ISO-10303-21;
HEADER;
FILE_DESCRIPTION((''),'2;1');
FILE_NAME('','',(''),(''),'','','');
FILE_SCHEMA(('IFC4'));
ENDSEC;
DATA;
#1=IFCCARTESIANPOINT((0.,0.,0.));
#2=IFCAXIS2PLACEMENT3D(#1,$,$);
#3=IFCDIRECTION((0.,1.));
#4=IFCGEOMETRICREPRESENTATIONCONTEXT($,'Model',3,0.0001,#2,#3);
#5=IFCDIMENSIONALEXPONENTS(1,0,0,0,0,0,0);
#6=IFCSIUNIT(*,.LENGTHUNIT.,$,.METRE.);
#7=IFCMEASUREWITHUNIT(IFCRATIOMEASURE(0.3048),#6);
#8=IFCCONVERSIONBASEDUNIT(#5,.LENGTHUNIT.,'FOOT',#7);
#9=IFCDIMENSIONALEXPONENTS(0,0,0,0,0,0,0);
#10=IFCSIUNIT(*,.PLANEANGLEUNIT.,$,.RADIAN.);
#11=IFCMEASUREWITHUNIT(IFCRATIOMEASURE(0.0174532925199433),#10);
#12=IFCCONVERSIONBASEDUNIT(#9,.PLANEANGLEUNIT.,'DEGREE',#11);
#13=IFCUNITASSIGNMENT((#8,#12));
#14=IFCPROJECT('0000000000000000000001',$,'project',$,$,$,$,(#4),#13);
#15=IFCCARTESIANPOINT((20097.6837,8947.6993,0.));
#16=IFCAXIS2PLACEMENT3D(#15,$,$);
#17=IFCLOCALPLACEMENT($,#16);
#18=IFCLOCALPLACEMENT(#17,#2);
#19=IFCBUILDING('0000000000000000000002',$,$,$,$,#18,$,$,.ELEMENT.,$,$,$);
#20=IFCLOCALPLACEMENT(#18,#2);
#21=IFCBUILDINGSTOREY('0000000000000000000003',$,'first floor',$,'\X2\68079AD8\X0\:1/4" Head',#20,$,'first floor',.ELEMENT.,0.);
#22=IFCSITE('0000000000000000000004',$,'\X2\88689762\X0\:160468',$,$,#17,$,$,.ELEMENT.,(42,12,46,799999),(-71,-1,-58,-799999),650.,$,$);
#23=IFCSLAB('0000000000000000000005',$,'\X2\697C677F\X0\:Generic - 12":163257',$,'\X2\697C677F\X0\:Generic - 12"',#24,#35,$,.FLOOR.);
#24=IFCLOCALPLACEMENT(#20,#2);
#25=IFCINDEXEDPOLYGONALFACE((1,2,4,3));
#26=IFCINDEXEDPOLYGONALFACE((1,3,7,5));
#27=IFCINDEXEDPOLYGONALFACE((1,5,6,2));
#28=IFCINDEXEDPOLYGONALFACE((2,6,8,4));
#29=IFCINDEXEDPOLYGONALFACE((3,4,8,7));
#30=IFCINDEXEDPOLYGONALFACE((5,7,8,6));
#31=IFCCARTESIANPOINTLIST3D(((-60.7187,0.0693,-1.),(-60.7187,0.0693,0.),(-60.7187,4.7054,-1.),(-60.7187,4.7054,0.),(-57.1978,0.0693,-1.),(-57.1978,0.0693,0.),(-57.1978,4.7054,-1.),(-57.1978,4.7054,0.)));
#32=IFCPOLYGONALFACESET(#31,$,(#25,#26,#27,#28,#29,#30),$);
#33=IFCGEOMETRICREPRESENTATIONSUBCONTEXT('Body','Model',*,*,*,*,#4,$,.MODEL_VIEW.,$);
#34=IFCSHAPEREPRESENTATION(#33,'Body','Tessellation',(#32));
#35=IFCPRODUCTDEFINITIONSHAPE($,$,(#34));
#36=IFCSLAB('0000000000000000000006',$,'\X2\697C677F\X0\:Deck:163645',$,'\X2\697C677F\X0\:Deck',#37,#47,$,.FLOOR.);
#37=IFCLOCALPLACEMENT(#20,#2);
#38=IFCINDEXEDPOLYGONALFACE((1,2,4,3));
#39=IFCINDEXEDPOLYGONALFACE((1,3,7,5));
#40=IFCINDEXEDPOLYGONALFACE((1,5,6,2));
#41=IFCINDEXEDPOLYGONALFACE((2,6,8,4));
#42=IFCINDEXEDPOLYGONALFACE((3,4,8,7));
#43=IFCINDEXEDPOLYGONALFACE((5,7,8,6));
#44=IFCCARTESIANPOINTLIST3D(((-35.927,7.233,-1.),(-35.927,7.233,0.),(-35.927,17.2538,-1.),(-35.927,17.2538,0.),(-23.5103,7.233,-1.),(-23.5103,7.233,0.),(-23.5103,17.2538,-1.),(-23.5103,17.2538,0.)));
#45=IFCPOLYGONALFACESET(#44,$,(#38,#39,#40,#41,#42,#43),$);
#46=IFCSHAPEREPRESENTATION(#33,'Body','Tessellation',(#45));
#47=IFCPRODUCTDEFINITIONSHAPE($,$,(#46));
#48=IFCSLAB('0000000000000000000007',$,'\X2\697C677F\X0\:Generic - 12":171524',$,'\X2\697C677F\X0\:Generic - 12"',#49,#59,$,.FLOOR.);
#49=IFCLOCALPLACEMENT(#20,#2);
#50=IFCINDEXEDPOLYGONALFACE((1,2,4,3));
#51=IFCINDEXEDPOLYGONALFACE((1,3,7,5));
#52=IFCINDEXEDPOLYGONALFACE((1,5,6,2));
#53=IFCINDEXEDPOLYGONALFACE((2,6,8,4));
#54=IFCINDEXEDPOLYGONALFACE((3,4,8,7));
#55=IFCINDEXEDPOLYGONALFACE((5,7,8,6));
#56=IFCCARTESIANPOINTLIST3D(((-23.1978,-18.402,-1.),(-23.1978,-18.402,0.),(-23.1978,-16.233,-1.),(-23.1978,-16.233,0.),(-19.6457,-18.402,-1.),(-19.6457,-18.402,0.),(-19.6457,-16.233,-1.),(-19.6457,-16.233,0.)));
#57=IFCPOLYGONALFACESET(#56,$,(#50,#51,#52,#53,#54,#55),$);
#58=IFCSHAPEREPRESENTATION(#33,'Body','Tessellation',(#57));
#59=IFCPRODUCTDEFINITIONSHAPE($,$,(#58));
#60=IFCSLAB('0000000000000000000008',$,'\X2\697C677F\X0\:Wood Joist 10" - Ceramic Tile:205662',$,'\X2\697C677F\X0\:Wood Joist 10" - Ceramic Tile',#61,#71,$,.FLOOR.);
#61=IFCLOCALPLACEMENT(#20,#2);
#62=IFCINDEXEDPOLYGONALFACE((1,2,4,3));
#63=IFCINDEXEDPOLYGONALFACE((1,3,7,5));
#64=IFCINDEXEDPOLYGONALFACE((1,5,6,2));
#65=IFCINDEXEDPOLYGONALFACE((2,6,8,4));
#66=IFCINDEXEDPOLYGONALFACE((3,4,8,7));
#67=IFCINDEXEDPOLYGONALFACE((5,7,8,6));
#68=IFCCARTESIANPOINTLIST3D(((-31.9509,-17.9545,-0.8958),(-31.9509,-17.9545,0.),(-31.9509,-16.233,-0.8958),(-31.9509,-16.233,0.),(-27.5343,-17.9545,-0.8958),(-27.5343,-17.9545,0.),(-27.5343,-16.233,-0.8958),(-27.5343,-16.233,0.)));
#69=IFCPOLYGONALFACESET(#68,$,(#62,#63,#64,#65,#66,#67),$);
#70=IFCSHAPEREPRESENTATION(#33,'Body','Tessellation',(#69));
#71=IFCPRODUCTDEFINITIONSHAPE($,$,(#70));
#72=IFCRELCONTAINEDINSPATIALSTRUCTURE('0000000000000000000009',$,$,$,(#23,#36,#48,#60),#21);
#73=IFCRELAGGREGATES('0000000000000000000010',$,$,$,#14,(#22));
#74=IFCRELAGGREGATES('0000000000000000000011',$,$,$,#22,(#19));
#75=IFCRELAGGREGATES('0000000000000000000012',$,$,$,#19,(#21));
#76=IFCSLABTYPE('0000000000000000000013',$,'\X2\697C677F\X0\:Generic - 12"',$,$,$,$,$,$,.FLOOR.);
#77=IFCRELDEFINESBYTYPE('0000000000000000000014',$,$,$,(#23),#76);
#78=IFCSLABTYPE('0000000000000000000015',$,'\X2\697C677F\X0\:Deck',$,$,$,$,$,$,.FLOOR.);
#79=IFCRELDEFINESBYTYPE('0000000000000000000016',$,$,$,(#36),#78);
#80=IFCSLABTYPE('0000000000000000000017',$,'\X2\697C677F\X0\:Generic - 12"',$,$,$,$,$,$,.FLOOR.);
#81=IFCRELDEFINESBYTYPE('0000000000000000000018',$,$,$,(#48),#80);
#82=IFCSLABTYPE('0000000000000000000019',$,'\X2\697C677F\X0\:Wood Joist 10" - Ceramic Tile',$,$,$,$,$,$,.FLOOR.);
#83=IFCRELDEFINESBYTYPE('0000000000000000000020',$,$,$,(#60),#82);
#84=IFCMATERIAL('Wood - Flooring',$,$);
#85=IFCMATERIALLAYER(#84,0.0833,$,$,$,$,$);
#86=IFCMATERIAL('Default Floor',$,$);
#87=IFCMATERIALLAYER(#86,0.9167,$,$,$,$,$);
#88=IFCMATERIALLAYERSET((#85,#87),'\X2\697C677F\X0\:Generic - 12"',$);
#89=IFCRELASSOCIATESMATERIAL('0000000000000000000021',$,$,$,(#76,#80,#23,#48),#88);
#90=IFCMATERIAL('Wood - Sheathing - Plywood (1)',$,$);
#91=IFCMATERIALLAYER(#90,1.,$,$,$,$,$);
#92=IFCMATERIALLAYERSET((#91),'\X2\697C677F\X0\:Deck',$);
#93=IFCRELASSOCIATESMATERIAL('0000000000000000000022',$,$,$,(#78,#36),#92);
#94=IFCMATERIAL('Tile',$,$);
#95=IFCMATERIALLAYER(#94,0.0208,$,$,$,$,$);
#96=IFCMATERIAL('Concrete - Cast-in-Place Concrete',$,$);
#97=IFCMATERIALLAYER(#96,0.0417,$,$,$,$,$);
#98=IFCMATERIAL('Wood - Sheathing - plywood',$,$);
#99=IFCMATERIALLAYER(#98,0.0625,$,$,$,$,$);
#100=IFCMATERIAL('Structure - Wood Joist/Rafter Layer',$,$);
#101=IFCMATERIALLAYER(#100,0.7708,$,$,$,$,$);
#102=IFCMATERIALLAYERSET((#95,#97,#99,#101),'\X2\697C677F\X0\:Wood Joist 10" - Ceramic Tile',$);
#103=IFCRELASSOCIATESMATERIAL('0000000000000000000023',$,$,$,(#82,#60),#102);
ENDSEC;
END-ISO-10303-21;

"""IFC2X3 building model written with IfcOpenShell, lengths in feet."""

from ifc_helpers import new_model, entity, si_unit, converted_unit, direction, frame, frame_2d, origin, origin_2d_with_axis, place, context, subcontext, project, spatial, rectangle, extrude, material, layer, layer_set, layer_usage, type_object, element, save


model = new_model("IFC2X3")

# Units and contexts
model_context = context("Model", 3, precision=0.0001, world=origin(), true_north=direction((0.0, 1.0)))
body_context = subcontext(model_context, "Body", "Model", "MODEL_VIEW")
ifc_project = project(units=[converted_unit("LENGTHUNIT", "FOOT", entity("IfcRatioMeasure", 0.3048), si_unit("LENGTHUNIT", "METRE"), dimensions=[1, 0, 0, 0, 0, 0, 0]), converted_unit("PLANEANGLEUNIT", "DEGREE", entity("IfcRatioMeasure", 0.0174532925199433), si_unit("PLANEANGLEUNIT", "RADIAN"), dimensions=[0, 0, 0, 0, 0, 0, 0])], contexts=[model_context])

# Site, building, storey
site_placement = place(None, frame((20097.6837, 8947.6993, 0.0)))
site = spatial("IfcSite", under=ifc_project, at=site_placement, Name="表面:160468", CompositionType="ELEMENT", RefLatitude=(42, 12, 46, 799999), RefLongitude=(-71, -1, -58, -799999), RefElevation=650.0)
building_placement = place(site_placement, origin())
building = spatial("IfcBuilding", under=site, at=building_placement, CompositionType="ELEMENT")
storey_placement = place(building_placement, origin())
storey = spatial("IfcBuildingStorey", under=building, at=storey_placement, Name="first floor", ObjectType="标高:1/4\" Head", LongName="first floor", CompositionType="ELEMENT", Elevation=0.0)

# Slabs
ifc_material_1 = material(Name="Wood - Flooring")
ifc_layer_1 = layer(ifc_material_1, 0.0833)
ifc_material_2 = material(Name="Default Floor")
ifc_layer_2 = layer(ifc_material_2, 0.9167)
ifc_layer_set_1 = layer_set([ifc_layer_1, ifc_layer_2], Name="楼板:Generic - 12\"")
ifc_layer_usage_1 = layer_usage(ifc_layer_set_1, "AXIS3", "POSITIVE", 0.0)
slab_type_1 = type_object("IfcSlabType", Name="楼板:Generic - 12\"", PredefinedType="FLOOR", material=ifc_layer_set_1)
slab_1_placement = place(storey_placement, origin())
element("IfcSlab", 1, at=slab_1_placement, inside=storey, type_object=slab_type_1, material=ifc_layer_usage_1, Name="楼板:Generic - 12\":163257", ObjectType="楼板:Generic - 12\"", PredefinedType="FLOOR", context=body_context, shape_type="SweptSolid", body=[
    extrude(rectangle(XDim=4.6361, YDim=3.5208, at=frame_2d((0.0, 0.0), x_axis=(1.0, 0.0))), frame((-58.9582, 2.3874, 0.0), z_axis=(0.0, 0.0, -1.0), x_axis=(0.0, 1.0, 0.0)), (0.0, 0.0, 1.0), 1.0),
])
ifc_material_3 = material(Name="Wood - Sheathing - Plywood (1)")
ifc_layer_3 = layer(ifc_material_3, 1.0)
ifc_layer_set_2 = layer_set([ifc_layer_3], Name="楼板:Deck")
ifc_layer_usage_2 = layer_usage(ifc_layer_set_2, "AXIS3", "POSITIVE", 0.0)
slab_type_2 = type_object("IfcSlabType", Name="楼板:Deck", PredefinedType="FLOOR", material=ifc_layer_set_2)
slab_2_placement = place(storey_placement, origin())
element("IfcSlab", 2, at=slab_2_placement, inside=storey, type_object=slab_type_2, material=ifc_layer_usage_2, Name="楼板:Deck:163645", ObjectType="楼板:Deck", PredefinedType="FLOOR", context=body_context, shape_type="SweptSolid", body=[
    extrude(rectangle(XDim=10.0208, YDim=12.4167, at=frame_2d((0.0, 0.0), x_axis=(1.0, 0.0))), frame((-29.7187, 12.2434, 0.0), z_axis=(0.0, 0.0, -1.0), x_axis=(0.0, 1.0, 0.0)), (0.0, 0.0, 1.0), 1.0),
])
ifc_layer_usage_3 = layer_usage(ifc_layer_set_1, "AXIS3", "POSITIVE", 0.0)
slab_type_3 = type_object("IfcSlabType", Name="楼板:Generic - 12\"", PredefinedType="FLOOR", material=ifc_layer_set_1)
slab_3_placement = place(storey_placement, origin())
element("IfcSlab", 3, at=slab_3_placement, inside=storey, type_object=slab_type_3, material=ifc_layer_usage_3, Name="楼板:Generic - 12\":171524", ObjectType="楼板:Generic - 12\"", PredefinedType="FLOOR", context=body_context, shape_type="SweptSolid", body=[
    extrude(rectangle(XDim=2.1691, YDim=3.5521, at=origin_2d_with_axis()), frame((-21.4218, -17.3175, 0.0), z_axis=(0.0, 0.0, -1.0), x_axis=(0.0, 1.0, 0.0)), (0.0, 0.0, 1.0), 1.0),
])
ifc_material_4 = material(Name="Tile")
ifc_layer_4 = layer(ifc_material_4, 0.0208)
ifc_material_5 = material(Name="Concrete - Cast-in-Place Concrete")
ifc_layer_5 = layer(ifc_material_5, 0.0417)
ifc_material_6 = material(Name="Wood - Sheathing - plywood")
ifc_layer_6 = layer(ifc_material_6, 0.0625)
ifc_material_7 = material(Name="Structure - Wood Joist/Rafter Layer")
ifc_layer_7 = layer(ifc_material_7, 0.7708)
ifc_layer_set_3 = layer_set([ifc_layer_4, ifc_layer_5, ifc_layer_6, ifc_layer_7], Name="楼板:Wood Joist 10\" - Ceramic Tile")
ifc_layer_usage_4 = layer_usage(ifc_layer_set_3, "AXIS3", "POSITIVE", 0.0)
slab_type_4 = type_object("IfcSlabType", Name="楼板:Wood Joist 10\" - Ceramic Tile", PredefinedType="FLOOR", material=ifc_layer_set_3)
slab_4_placement = place(storey_placement, origin())
element("IfcSlab", 4, at=slab_4_placement, inside=storey, type_object=slab_type_4, material=ifc_layer_usage_4, Name="楼板:Wood Joist 10\" - Ceramic Tile:205662", ObjectType="楼板:Wood Joist 10\" - Ceramic Tile", PredefinedType="FLOOR", context=body_context, shape_type="SweptSolid", body=[
    extrude(rectangle(XDim=1.7216, YDim=4.4167, at=frame_2d((0.0, 0.0), x_axis=(1.0, 0.0))), frame((-29.7426, -17.0938, 0.0), z_axis=(0.0, 0.0, -1.0), x_axis=(0.0, 1.0, 0.0)), (0.0, 0.0, 1.0), 0.8958),
])

save(model, "model.ifc")
